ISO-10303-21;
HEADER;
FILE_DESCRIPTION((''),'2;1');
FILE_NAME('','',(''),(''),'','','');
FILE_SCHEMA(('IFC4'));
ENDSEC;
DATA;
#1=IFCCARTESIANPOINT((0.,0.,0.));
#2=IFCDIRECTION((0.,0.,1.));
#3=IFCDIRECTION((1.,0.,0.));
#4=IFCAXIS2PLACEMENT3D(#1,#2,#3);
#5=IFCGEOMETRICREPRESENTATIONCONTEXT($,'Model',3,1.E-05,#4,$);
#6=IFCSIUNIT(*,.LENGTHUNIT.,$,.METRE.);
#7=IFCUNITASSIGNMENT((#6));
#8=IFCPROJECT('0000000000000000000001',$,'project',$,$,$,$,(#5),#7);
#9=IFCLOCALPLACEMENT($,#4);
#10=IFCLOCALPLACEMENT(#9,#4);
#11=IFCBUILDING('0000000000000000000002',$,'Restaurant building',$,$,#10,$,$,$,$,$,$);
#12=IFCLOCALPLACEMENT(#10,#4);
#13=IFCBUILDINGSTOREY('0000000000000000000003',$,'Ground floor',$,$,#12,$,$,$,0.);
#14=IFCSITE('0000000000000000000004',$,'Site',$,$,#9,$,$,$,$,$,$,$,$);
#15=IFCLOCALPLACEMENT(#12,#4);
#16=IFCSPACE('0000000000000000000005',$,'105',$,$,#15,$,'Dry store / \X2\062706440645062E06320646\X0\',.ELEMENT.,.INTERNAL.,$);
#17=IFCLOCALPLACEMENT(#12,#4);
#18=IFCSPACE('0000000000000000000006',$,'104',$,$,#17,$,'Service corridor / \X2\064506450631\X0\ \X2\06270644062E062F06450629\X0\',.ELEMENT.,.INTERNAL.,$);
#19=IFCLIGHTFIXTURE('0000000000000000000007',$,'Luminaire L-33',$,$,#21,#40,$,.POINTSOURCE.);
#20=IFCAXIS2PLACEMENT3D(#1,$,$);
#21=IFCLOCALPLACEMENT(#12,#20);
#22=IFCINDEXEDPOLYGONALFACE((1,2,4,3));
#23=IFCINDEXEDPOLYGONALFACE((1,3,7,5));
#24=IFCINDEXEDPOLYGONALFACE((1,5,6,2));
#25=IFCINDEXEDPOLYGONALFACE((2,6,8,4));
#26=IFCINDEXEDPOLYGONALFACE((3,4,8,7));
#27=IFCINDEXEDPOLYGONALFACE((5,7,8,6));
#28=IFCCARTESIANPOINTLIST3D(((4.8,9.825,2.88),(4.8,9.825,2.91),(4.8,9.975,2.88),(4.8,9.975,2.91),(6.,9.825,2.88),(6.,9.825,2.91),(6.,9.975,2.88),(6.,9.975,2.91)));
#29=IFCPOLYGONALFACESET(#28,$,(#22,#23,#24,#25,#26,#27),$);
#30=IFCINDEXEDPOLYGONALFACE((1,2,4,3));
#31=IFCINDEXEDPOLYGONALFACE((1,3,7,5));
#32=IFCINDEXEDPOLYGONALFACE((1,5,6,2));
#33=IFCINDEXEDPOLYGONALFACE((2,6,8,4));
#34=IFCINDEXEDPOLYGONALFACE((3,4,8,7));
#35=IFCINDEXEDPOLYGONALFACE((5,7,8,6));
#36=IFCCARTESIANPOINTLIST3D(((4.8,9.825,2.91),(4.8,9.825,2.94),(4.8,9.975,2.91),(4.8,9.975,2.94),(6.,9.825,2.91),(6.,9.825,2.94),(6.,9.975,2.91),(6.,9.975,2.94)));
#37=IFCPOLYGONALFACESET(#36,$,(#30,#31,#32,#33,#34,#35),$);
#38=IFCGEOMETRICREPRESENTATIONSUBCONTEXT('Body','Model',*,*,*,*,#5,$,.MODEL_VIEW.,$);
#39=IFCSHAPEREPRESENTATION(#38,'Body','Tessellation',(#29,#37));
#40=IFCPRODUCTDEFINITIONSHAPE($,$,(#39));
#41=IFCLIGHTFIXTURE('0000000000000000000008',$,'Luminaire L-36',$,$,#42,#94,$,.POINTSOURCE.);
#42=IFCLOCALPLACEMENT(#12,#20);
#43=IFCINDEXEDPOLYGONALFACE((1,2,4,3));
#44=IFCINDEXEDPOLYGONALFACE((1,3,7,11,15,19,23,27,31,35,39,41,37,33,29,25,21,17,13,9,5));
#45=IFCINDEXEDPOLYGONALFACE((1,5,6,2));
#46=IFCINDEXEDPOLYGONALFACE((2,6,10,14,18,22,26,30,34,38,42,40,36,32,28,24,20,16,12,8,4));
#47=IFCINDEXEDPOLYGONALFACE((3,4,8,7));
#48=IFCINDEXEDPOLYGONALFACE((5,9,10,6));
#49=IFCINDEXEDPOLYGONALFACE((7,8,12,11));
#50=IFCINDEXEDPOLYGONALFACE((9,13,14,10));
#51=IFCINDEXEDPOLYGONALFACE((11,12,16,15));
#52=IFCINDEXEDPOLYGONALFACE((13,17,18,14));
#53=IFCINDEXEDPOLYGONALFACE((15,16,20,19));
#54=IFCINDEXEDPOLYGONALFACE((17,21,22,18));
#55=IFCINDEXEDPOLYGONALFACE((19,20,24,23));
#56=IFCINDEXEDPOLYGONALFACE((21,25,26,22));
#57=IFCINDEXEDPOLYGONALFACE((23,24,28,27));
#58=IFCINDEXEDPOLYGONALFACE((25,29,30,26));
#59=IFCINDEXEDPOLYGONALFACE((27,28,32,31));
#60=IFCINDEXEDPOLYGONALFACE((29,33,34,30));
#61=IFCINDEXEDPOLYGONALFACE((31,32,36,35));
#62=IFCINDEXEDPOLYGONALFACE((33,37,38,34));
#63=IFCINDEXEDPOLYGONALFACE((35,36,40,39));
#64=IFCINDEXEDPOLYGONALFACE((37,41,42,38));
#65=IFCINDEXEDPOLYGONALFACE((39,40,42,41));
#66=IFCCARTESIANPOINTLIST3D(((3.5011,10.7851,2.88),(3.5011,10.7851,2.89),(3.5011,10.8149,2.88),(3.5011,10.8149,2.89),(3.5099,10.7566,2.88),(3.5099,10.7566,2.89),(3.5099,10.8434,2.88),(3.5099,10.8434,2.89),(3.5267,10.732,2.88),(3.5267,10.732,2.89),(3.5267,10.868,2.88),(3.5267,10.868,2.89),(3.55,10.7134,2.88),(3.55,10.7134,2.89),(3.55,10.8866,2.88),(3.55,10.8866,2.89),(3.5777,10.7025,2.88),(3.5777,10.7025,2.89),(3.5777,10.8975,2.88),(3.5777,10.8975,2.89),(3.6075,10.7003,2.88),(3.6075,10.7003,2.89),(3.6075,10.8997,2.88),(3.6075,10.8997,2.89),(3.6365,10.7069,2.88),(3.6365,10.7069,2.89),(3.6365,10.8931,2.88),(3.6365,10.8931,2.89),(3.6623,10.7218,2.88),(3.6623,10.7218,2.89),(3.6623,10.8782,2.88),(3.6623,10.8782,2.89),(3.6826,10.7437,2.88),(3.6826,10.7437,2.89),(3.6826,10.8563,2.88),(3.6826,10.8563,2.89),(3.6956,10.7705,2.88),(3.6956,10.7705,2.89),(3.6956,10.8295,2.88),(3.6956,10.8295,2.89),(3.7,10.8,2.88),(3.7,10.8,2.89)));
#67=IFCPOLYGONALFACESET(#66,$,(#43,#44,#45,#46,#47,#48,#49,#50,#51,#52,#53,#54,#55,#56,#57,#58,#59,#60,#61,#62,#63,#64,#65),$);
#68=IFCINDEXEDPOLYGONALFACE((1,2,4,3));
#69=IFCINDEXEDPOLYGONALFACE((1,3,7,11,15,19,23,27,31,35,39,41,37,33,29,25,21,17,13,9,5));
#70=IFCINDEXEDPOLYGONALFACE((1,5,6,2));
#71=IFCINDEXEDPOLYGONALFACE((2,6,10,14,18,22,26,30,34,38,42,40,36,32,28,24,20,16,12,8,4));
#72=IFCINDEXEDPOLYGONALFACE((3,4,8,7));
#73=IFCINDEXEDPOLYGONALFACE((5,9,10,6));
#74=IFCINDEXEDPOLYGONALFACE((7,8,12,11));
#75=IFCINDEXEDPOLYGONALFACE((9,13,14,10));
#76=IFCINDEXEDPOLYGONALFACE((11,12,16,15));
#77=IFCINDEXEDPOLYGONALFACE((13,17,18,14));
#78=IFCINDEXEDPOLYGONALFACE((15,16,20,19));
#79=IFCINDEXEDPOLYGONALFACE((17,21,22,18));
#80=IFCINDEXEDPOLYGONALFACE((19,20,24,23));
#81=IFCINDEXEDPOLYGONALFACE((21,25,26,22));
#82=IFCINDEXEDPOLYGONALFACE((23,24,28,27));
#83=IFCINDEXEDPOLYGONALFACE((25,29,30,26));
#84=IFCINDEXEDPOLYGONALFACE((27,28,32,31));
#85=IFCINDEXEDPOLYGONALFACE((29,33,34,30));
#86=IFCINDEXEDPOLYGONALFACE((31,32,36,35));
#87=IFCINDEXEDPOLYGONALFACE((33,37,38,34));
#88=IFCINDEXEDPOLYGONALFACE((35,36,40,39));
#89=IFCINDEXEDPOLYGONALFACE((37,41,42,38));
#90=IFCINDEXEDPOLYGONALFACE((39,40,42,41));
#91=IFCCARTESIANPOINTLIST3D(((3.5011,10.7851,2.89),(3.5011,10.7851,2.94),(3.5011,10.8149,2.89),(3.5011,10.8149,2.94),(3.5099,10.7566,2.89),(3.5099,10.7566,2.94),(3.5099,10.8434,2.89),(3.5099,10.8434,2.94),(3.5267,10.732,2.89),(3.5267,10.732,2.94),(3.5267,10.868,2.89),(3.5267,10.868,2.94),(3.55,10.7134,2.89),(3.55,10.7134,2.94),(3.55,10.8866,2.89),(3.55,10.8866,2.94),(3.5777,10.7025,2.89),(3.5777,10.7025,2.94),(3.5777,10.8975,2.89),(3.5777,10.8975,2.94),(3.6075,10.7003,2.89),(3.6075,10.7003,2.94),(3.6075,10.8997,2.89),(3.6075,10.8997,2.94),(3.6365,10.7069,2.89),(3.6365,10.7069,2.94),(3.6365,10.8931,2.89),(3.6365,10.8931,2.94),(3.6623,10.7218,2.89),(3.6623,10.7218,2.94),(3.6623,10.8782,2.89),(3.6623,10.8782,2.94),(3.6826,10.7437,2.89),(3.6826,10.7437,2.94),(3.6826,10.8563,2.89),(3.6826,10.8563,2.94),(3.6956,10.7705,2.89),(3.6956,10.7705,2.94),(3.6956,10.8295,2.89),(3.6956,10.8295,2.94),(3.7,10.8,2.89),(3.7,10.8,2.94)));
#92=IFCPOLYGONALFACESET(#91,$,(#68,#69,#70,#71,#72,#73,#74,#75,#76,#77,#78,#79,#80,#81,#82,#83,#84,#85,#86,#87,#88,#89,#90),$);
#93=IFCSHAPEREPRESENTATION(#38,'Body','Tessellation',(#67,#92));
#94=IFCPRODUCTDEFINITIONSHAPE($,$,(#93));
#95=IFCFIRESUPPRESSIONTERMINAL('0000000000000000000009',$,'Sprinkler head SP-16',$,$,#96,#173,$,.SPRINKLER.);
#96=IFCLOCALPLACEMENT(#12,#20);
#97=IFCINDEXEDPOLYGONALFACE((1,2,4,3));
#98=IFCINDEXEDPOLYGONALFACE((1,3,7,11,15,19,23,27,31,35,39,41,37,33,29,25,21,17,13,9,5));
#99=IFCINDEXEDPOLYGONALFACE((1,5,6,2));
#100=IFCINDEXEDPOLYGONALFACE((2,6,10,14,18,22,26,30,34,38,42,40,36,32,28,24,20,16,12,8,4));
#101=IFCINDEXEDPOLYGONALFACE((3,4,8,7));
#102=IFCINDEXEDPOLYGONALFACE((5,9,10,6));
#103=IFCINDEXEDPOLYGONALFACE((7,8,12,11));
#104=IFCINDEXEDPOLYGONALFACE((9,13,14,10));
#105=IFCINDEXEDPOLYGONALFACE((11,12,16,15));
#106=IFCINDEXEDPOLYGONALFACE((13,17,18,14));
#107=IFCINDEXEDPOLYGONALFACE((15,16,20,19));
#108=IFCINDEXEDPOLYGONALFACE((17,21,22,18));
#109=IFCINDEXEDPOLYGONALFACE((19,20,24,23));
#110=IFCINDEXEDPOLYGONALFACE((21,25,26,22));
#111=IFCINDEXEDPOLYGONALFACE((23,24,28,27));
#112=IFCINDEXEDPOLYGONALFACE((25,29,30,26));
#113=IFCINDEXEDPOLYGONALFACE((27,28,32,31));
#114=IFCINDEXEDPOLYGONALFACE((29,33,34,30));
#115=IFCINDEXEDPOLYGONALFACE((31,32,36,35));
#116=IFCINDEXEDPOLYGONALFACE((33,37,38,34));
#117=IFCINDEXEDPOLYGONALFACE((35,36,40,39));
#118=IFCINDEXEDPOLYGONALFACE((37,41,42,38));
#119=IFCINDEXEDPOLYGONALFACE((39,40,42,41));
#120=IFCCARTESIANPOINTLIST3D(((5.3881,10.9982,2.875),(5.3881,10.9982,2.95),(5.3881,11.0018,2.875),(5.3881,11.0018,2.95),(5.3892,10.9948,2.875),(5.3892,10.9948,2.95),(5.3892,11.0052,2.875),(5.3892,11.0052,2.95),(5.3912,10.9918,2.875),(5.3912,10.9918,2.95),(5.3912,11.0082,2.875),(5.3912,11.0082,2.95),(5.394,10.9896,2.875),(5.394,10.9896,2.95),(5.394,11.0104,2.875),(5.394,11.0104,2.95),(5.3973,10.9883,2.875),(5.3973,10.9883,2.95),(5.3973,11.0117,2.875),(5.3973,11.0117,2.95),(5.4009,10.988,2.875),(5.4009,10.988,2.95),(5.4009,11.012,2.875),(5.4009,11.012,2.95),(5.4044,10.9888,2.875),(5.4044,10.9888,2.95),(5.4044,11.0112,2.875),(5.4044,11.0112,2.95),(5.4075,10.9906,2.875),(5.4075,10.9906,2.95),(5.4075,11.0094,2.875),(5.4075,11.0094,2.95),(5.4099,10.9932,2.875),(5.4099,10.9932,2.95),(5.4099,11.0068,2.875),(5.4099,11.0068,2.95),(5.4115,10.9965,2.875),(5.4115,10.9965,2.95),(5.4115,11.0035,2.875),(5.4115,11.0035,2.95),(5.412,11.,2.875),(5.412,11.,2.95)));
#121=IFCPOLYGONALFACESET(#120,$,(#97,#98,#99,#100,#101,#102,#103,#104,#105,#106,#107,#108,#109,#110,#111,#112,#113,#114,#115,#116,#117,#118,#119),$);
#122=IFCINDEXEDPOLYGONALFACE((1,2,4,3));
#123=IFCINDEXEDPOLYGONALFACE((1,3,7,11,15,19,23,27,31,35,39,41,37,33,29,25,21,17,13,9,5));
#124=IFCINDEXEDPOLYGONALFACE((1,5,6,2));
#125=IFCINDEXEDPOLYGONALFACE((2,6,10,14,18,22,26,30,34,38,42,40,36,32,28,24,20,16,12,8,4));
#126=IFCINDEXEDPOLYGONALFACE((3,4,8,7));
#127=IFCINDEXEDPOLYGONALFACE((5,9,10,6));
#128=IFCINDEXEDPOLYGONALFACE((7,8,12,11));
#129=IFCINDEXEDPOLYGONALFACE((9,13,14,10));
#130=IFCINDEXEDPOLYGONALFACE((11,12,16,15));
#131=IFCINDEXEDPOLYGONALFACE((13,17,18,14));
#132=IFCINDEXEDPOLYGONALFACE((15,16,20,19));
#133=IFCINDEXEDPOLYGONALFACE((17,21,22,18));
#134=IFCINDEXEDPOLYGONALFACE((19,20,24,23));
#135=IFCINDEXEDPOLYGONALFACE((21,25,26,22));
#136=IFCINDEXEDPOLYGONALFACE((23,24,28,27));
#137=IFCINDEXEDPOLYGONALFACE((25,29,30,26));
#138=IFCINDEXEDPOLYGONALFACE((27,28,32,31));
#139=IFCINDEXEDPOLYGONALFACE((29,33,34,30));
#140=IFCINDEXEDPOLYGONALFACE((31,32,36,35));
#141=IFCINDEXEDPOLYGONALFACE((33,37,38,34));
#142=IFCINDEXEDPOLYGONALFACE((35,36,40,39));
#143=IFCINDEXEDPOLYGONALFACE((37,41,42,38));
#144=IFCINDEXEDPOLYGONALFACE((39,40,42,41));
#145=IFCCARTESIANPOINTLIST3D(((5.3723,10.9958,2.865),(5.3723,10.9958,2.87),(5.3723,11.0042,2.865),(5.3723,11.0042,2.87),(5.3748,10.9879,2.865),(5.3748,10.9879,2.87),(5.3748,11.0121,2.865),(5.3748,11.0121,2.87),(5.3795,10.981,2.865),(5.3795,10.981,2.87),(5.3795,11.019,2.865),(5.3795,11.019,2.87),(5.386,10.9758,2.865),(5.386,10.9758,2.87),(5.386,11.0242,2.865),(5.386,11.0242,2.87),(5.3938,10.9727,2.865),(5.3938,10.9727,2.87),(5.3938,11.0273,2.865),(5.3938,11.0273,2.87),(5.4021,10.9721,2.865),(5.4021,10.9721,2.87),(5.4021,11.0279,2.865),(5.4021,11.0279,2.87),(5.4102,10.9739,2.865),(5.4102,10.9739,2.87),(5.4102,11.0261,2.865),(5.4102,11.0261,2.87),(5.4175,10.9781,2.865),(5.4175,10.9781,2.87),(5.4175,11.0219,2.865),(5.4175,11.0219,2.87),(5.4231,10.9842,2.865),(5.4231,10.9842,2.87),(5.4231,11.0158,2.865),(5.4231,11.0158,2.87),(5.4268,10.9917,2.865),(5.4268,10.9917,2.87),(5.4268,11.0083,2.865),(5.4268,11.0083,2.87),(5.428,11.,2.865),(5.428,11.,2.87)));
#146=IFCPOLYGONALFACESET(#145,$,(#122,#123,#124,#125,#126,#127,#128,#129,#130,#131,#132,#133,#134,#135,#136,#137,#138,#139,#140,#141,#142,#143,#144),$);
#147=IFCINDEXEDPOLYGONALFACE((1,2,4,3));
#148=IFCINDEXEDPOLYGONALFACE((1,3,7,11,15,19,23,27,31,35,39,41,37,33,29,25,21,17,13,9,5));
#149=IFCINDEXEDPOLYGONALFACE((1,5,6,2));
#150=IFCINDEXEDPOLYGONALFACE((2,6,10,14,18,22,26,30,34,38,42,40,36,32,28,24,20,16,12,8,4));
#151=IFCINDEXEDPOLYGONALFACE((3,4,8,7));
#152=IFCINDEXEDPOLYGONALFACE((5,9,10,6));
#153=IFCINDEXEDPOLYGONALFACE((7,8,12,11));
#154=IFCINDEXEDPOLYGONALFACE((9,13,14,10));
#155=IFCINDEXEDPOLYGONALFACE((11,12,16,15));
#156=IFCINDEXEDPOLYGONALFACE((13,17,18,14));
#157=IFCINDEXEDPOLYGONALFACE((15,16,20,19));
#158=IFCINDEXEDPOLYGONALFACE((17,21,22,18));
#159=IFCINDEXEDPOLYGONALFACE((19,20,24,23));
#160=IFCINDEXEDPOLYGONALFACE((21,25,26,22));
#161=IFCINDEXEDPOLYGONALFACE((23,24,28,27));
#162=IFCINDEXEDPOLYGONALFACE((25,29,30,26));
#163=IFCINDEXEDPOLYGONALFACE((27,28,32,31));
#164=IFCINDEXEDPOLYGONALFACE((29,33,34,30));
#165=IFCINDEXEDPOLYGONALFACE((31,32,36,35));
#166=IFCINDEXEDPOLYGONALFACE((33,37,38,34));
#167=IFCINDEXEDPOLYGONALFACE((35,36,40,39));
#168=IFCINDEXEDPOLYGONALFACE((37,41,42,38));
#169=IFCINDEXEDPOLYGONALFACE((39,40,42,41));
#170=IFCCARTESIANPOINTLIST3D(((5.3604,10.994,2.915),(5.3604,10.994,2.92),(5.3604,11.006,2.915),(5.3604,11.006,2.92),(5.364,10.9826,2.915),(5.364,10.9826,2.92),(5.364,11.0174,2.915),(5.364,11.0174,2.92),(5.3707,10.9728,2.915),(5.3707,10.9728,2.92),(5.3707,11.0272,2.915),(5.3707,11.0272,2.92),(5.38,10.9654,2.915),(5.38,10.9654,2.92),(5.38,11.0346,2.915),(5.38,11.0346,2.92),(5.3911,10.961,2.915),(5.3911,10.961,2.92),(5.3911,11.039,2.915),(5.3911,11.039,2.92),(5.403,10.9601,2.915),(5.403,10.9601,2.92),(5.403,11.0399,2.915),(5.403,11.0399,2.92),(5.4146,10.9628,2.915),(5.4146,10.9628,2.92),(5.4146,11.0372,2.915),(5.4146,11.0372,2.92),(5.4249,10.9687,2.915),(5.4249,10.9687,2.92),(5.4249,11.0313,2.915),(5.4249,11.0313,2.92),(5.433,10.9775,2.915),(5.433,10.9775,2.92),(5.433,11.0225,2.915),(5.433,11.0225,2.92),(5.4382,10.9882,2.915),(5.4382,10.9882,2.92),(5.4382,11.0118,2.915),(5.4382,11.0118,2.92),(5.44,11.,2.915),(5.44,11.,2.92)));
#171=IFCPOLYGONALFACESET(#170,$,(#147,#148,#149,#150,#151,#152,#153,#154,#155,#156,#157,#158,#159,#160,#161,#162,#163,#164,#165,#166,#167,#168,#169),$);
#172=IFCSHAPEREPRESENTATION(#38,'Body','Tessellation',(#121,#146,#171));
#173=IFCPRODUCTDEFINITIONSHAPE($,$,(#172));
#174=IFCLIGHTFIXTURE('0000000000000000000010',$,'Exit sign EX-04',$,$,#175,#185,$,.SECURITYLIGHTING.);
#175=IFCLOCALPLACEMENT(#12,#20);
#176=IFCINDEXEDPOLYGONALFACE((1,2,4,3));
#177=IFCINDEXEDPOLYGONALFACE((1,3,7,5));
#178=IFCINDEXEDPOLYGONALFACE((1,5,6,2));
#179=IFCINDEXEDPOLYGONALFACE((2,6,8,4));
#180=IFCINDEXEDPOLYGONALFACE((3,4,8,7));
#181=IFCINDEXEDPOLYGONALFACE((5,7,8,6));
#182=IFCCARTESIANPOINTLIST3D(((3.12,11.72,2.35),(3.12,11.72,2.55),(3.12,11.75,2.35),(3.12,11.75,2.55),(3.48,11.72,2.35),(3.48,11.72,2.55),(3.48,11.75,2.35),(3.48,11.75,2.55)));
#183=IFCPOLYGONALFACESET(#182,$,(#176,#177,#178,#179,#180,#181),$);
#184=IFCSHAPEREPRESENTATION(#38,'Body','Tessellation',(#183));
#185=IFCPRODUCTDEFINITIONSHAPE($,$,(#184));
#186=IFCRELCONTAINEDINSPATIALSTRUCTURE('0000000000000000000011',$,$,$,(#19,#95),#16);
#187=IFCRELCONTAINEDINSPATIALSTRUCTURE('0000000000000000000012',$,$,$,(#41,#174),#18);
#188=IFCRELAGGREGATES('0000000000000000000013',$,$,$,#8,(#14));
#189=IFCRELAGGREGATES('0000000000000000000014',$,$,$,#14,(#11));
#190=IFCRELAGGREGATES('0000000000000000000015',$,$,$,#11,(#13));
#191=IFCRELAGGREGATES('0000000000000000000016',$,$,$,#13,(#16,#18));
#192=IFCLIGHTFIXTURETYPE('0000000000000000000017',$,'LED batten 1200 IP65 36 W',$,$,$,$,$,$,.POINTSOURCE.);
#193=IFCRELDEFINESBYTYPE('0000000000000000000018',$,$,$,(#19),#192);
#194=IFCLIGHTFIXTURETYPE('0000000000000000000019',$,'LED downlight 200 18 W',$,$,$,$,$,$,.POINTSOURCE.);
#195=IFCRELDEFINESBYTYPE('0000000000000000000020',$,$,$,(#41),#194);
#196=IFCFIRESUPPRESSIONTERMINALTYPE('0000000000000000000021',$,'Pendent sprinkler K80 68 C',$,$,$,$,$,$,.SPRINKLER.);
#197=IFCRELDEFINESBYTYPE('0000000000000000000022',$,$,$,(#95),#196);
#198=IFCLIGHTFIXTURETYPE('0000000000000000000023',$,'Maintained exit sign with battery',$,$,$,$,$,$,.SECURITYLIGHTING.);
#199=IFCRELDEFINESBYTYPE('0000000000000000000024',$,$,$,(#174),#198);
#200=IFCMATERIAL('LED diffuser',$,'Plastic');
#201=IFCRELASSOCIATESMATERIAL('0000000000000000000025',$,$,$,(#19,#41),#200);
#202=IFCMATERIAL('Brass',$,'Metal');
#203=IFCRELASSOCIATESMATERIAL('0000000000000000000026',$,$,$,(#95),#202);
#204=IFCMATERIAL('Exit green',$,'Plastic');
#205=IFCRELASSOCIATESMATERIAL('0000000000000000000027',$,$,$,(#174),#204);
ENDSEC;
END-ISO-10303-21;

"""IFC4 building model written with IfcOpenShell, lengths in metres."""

from ifc_helpers import new_model, si_unit, frame, origin, origin_with_axes, origin_2d, place, context, subcontext, project, spatial, rectangle, circle, extrude, source, transform, mapped, material, type_object, type_shapes, element, save


model = new_model("IFC4")

# Units and contexts
model_context = context("Model", 3, precision=1e-05, world=origin_with_axes())
body_context = subcontext(model_context, "Body", "Model", "MODEL_VIEW")
ifc_project = project(units=[si_unit("LENGTHUNIT", "METRE")], contexts=[model_context])

# Site, building, storey, space
site_placement = place(None, origin_with_axes())
site = spatial("IfcSite", under=ifc_project, at=site_placement, Name="Site")
building_placement = place(site_placement, origin_with_axes())
building = spatial("IfcBuilding", under=site, at=building_placement, Name="Restaurant building")
storey_placement = place(building_placement, origin_with_axes())
storey = spatial("IfcBuildingStorey", under=building, at=storey_placement, Name="Ground floor", Elevation=0.0)
space_1_placement = place(storey_placement, origin_with_axes())
space_1 = spatial("IfcSpace", under=storey, at=space_1_placement, Name="105", LongName="Dry store / المخزن", CompositionType="ELEMENT", PredefinedType="INTERNAL")

# Light fixture
ifc_material_1 = material(Name="LED diffuser", Category="Plastic")
light_fixture_type_1 = type_object("IfcLightFixtureType", Name="LED batten 1200 IP65 36 W", PredefinedType="POINTSOURCE")
shared_shape_1 = source(origin(), body_context, "Body", "SweptSolid", [
    extrude(rectangle(XDim=1.2, YDim=0.15, at=origin_2d()), frame((0.0, 0.0, -0.06)), (0.0, 0.0, 1.0), 0.03),
    extrude(rectangle(XDim=1.2, YDim=0.15, at=origin_2d()), frame((0.0, 0.0, -0.03)), (0.0, 0.0, 1.0), 0.03),
])
type_shapes(light_fixture_type_1, [shared_shape_1])
light_fixture_1_placement = place(storey_placement, frame((5.4, 9.9, 2.94)))
element("IfcLightFixture", 1, at=light_fixture_1_placement, inside=space_1, type_object=light_fixture_type_1, material=ifc_material_1, Name="Luminaire L-33", PredefinedType="POINTSOURCE", context=body_context, shape_type="MappedRepresentation", body=[
    mapped(shared_shape_1, transform((0.0, 0.0, 0.0))),
])

# Shared definitions
space_2_placement = place(storey_placement, origin_with_axes())
space_2 = spatial("IfcSpace", under=storey, at=space_2_placement, Name="104", LongName="Service corridor / ممر الخدمة", CompositionType="ELEMENT", PredefinedType="INTERNAL")

# Light fixture
light_fixture_type_2 = type_object("IfcLightFixtureType", Name="LED downlight 200 18 W", PredefinedType="POINTSOURCE")
shared_shape_2 = source(origin(), body_context, "Body", "SweptSolid", [
    extrude(circle(Radius=0.1, at=origin_2d()), frame((0.0, 0.0, -0.06)), (0.0, 0.0, 1.0), 0.01),
    extrude(circle(Radius=0.1, at=origin_2d()), frame((0.0, 0.0, -0.05)), (0.0, 0.0, 1.0), 0.05),
])
type_shapes(light_fixture_type_2, [shared_shape_2])
light_fixture_2_placement = place(storey_placement, frame((3.6, 10.8, 2.94)))
element("IfcLightFixture", 2, at=light_fixture_2_placement, inside=space_2, type_object=light_fixture_type_2, material=ifc_material_1, Name="Luminaire L-36", PredefinedType="POINTSOURCE", context=body_context, shape_type="MappedRepresentation", body=[
    mapped(shared_shape_2, transform((0.0, 0.0, 0.0))),
])

# Fire suppression terminal
ifc_material_2 = material(Name="Brass", Category="Metal")
fire_suppression_terminal_type = type_object("IfcFireSuppressionTerminalType", Name="Pendent sprinkler K80 68 C", PredefinedType="SPRINKLER")
shared_shape_3 = source(origin(), body_context, "Body", "SweptSolid", [
    extrude(circle(Radius=0.012, at=origin_2d()), frame((0.0, 0.0, -0.075)), (0.0, 0.0, 1.0), 0.075),
    extrude(circle(Radius=0.028, at=origin_2d()), frame((0.0, 0.0, -0.085)), (0.0, 0.0, 1.0), 0.005),
    extrude(circle(Radius=0.04, at=origin_2d()), frame((0.0, 0.0, -0.035)), (0.0, 0.0, 1.0), 0.005),
])
type_shapes(fire_suppression_terminal_type, [shared_shape_3])
fire_suppression_terminal_placement = place(storey_placement, frame((5.4, 11.0, 2.95)))
element("IfcFireSuppressionTerminal", 3, at=fire_suppression_terminal_placement, inside=space_1, type_object=fire_suppression_terminal_type, material=ifc_material_2, Name="Sprinkler head SP-16", PredefinedType="SPRINKLER", context=body_context, shape_type="MappedRepresentation", body=[
    mapped(shared_shape_3, transform((0.0, 0.0, 0.0))),
])

# Light fixture
ifc_material_3 = material(Name="Exit green", Category="Plastic")
light_fixture_type_3 = type_object("IfcLightFixtureType", Name="Maintained exit sign with battery", PredefinedType="SECURITYLIGHTING")
shared_shape_4 = source(origin(), body_context, "Body", "SweptSolid", [
    extrude(rectangle(XDim=0.36, YDim=0.03, at=origin_2d()), frame((0.0, 0.015, -0.1)), (0.0, 0.0, 1.0), 0.2),
])
type_shapes(light_fixture_type_3, [shared_shape_4])
light_fixture_3_placement = place(storey_placement, frame((3.3, 11.75, 2.45), z_axis=(0.0, 0.0, 1.0), x_axis=(-1.0, 0.0, 0.0)))
element("IfcLightFixture", 4, at=light_fixture_3_placement, inside=space_2, type_object=light_fixture_type_3, material=ifc_material_3, Name="Exit sign EX-04", PredefinedType="SECURITYLIGHTING", context=body_context, shape_type="MappedRepresentation", body=[
    mapped(shared_shape_4, transform((0.0, 0.0, 0.0))),
])

save(model, "model.ifc")
